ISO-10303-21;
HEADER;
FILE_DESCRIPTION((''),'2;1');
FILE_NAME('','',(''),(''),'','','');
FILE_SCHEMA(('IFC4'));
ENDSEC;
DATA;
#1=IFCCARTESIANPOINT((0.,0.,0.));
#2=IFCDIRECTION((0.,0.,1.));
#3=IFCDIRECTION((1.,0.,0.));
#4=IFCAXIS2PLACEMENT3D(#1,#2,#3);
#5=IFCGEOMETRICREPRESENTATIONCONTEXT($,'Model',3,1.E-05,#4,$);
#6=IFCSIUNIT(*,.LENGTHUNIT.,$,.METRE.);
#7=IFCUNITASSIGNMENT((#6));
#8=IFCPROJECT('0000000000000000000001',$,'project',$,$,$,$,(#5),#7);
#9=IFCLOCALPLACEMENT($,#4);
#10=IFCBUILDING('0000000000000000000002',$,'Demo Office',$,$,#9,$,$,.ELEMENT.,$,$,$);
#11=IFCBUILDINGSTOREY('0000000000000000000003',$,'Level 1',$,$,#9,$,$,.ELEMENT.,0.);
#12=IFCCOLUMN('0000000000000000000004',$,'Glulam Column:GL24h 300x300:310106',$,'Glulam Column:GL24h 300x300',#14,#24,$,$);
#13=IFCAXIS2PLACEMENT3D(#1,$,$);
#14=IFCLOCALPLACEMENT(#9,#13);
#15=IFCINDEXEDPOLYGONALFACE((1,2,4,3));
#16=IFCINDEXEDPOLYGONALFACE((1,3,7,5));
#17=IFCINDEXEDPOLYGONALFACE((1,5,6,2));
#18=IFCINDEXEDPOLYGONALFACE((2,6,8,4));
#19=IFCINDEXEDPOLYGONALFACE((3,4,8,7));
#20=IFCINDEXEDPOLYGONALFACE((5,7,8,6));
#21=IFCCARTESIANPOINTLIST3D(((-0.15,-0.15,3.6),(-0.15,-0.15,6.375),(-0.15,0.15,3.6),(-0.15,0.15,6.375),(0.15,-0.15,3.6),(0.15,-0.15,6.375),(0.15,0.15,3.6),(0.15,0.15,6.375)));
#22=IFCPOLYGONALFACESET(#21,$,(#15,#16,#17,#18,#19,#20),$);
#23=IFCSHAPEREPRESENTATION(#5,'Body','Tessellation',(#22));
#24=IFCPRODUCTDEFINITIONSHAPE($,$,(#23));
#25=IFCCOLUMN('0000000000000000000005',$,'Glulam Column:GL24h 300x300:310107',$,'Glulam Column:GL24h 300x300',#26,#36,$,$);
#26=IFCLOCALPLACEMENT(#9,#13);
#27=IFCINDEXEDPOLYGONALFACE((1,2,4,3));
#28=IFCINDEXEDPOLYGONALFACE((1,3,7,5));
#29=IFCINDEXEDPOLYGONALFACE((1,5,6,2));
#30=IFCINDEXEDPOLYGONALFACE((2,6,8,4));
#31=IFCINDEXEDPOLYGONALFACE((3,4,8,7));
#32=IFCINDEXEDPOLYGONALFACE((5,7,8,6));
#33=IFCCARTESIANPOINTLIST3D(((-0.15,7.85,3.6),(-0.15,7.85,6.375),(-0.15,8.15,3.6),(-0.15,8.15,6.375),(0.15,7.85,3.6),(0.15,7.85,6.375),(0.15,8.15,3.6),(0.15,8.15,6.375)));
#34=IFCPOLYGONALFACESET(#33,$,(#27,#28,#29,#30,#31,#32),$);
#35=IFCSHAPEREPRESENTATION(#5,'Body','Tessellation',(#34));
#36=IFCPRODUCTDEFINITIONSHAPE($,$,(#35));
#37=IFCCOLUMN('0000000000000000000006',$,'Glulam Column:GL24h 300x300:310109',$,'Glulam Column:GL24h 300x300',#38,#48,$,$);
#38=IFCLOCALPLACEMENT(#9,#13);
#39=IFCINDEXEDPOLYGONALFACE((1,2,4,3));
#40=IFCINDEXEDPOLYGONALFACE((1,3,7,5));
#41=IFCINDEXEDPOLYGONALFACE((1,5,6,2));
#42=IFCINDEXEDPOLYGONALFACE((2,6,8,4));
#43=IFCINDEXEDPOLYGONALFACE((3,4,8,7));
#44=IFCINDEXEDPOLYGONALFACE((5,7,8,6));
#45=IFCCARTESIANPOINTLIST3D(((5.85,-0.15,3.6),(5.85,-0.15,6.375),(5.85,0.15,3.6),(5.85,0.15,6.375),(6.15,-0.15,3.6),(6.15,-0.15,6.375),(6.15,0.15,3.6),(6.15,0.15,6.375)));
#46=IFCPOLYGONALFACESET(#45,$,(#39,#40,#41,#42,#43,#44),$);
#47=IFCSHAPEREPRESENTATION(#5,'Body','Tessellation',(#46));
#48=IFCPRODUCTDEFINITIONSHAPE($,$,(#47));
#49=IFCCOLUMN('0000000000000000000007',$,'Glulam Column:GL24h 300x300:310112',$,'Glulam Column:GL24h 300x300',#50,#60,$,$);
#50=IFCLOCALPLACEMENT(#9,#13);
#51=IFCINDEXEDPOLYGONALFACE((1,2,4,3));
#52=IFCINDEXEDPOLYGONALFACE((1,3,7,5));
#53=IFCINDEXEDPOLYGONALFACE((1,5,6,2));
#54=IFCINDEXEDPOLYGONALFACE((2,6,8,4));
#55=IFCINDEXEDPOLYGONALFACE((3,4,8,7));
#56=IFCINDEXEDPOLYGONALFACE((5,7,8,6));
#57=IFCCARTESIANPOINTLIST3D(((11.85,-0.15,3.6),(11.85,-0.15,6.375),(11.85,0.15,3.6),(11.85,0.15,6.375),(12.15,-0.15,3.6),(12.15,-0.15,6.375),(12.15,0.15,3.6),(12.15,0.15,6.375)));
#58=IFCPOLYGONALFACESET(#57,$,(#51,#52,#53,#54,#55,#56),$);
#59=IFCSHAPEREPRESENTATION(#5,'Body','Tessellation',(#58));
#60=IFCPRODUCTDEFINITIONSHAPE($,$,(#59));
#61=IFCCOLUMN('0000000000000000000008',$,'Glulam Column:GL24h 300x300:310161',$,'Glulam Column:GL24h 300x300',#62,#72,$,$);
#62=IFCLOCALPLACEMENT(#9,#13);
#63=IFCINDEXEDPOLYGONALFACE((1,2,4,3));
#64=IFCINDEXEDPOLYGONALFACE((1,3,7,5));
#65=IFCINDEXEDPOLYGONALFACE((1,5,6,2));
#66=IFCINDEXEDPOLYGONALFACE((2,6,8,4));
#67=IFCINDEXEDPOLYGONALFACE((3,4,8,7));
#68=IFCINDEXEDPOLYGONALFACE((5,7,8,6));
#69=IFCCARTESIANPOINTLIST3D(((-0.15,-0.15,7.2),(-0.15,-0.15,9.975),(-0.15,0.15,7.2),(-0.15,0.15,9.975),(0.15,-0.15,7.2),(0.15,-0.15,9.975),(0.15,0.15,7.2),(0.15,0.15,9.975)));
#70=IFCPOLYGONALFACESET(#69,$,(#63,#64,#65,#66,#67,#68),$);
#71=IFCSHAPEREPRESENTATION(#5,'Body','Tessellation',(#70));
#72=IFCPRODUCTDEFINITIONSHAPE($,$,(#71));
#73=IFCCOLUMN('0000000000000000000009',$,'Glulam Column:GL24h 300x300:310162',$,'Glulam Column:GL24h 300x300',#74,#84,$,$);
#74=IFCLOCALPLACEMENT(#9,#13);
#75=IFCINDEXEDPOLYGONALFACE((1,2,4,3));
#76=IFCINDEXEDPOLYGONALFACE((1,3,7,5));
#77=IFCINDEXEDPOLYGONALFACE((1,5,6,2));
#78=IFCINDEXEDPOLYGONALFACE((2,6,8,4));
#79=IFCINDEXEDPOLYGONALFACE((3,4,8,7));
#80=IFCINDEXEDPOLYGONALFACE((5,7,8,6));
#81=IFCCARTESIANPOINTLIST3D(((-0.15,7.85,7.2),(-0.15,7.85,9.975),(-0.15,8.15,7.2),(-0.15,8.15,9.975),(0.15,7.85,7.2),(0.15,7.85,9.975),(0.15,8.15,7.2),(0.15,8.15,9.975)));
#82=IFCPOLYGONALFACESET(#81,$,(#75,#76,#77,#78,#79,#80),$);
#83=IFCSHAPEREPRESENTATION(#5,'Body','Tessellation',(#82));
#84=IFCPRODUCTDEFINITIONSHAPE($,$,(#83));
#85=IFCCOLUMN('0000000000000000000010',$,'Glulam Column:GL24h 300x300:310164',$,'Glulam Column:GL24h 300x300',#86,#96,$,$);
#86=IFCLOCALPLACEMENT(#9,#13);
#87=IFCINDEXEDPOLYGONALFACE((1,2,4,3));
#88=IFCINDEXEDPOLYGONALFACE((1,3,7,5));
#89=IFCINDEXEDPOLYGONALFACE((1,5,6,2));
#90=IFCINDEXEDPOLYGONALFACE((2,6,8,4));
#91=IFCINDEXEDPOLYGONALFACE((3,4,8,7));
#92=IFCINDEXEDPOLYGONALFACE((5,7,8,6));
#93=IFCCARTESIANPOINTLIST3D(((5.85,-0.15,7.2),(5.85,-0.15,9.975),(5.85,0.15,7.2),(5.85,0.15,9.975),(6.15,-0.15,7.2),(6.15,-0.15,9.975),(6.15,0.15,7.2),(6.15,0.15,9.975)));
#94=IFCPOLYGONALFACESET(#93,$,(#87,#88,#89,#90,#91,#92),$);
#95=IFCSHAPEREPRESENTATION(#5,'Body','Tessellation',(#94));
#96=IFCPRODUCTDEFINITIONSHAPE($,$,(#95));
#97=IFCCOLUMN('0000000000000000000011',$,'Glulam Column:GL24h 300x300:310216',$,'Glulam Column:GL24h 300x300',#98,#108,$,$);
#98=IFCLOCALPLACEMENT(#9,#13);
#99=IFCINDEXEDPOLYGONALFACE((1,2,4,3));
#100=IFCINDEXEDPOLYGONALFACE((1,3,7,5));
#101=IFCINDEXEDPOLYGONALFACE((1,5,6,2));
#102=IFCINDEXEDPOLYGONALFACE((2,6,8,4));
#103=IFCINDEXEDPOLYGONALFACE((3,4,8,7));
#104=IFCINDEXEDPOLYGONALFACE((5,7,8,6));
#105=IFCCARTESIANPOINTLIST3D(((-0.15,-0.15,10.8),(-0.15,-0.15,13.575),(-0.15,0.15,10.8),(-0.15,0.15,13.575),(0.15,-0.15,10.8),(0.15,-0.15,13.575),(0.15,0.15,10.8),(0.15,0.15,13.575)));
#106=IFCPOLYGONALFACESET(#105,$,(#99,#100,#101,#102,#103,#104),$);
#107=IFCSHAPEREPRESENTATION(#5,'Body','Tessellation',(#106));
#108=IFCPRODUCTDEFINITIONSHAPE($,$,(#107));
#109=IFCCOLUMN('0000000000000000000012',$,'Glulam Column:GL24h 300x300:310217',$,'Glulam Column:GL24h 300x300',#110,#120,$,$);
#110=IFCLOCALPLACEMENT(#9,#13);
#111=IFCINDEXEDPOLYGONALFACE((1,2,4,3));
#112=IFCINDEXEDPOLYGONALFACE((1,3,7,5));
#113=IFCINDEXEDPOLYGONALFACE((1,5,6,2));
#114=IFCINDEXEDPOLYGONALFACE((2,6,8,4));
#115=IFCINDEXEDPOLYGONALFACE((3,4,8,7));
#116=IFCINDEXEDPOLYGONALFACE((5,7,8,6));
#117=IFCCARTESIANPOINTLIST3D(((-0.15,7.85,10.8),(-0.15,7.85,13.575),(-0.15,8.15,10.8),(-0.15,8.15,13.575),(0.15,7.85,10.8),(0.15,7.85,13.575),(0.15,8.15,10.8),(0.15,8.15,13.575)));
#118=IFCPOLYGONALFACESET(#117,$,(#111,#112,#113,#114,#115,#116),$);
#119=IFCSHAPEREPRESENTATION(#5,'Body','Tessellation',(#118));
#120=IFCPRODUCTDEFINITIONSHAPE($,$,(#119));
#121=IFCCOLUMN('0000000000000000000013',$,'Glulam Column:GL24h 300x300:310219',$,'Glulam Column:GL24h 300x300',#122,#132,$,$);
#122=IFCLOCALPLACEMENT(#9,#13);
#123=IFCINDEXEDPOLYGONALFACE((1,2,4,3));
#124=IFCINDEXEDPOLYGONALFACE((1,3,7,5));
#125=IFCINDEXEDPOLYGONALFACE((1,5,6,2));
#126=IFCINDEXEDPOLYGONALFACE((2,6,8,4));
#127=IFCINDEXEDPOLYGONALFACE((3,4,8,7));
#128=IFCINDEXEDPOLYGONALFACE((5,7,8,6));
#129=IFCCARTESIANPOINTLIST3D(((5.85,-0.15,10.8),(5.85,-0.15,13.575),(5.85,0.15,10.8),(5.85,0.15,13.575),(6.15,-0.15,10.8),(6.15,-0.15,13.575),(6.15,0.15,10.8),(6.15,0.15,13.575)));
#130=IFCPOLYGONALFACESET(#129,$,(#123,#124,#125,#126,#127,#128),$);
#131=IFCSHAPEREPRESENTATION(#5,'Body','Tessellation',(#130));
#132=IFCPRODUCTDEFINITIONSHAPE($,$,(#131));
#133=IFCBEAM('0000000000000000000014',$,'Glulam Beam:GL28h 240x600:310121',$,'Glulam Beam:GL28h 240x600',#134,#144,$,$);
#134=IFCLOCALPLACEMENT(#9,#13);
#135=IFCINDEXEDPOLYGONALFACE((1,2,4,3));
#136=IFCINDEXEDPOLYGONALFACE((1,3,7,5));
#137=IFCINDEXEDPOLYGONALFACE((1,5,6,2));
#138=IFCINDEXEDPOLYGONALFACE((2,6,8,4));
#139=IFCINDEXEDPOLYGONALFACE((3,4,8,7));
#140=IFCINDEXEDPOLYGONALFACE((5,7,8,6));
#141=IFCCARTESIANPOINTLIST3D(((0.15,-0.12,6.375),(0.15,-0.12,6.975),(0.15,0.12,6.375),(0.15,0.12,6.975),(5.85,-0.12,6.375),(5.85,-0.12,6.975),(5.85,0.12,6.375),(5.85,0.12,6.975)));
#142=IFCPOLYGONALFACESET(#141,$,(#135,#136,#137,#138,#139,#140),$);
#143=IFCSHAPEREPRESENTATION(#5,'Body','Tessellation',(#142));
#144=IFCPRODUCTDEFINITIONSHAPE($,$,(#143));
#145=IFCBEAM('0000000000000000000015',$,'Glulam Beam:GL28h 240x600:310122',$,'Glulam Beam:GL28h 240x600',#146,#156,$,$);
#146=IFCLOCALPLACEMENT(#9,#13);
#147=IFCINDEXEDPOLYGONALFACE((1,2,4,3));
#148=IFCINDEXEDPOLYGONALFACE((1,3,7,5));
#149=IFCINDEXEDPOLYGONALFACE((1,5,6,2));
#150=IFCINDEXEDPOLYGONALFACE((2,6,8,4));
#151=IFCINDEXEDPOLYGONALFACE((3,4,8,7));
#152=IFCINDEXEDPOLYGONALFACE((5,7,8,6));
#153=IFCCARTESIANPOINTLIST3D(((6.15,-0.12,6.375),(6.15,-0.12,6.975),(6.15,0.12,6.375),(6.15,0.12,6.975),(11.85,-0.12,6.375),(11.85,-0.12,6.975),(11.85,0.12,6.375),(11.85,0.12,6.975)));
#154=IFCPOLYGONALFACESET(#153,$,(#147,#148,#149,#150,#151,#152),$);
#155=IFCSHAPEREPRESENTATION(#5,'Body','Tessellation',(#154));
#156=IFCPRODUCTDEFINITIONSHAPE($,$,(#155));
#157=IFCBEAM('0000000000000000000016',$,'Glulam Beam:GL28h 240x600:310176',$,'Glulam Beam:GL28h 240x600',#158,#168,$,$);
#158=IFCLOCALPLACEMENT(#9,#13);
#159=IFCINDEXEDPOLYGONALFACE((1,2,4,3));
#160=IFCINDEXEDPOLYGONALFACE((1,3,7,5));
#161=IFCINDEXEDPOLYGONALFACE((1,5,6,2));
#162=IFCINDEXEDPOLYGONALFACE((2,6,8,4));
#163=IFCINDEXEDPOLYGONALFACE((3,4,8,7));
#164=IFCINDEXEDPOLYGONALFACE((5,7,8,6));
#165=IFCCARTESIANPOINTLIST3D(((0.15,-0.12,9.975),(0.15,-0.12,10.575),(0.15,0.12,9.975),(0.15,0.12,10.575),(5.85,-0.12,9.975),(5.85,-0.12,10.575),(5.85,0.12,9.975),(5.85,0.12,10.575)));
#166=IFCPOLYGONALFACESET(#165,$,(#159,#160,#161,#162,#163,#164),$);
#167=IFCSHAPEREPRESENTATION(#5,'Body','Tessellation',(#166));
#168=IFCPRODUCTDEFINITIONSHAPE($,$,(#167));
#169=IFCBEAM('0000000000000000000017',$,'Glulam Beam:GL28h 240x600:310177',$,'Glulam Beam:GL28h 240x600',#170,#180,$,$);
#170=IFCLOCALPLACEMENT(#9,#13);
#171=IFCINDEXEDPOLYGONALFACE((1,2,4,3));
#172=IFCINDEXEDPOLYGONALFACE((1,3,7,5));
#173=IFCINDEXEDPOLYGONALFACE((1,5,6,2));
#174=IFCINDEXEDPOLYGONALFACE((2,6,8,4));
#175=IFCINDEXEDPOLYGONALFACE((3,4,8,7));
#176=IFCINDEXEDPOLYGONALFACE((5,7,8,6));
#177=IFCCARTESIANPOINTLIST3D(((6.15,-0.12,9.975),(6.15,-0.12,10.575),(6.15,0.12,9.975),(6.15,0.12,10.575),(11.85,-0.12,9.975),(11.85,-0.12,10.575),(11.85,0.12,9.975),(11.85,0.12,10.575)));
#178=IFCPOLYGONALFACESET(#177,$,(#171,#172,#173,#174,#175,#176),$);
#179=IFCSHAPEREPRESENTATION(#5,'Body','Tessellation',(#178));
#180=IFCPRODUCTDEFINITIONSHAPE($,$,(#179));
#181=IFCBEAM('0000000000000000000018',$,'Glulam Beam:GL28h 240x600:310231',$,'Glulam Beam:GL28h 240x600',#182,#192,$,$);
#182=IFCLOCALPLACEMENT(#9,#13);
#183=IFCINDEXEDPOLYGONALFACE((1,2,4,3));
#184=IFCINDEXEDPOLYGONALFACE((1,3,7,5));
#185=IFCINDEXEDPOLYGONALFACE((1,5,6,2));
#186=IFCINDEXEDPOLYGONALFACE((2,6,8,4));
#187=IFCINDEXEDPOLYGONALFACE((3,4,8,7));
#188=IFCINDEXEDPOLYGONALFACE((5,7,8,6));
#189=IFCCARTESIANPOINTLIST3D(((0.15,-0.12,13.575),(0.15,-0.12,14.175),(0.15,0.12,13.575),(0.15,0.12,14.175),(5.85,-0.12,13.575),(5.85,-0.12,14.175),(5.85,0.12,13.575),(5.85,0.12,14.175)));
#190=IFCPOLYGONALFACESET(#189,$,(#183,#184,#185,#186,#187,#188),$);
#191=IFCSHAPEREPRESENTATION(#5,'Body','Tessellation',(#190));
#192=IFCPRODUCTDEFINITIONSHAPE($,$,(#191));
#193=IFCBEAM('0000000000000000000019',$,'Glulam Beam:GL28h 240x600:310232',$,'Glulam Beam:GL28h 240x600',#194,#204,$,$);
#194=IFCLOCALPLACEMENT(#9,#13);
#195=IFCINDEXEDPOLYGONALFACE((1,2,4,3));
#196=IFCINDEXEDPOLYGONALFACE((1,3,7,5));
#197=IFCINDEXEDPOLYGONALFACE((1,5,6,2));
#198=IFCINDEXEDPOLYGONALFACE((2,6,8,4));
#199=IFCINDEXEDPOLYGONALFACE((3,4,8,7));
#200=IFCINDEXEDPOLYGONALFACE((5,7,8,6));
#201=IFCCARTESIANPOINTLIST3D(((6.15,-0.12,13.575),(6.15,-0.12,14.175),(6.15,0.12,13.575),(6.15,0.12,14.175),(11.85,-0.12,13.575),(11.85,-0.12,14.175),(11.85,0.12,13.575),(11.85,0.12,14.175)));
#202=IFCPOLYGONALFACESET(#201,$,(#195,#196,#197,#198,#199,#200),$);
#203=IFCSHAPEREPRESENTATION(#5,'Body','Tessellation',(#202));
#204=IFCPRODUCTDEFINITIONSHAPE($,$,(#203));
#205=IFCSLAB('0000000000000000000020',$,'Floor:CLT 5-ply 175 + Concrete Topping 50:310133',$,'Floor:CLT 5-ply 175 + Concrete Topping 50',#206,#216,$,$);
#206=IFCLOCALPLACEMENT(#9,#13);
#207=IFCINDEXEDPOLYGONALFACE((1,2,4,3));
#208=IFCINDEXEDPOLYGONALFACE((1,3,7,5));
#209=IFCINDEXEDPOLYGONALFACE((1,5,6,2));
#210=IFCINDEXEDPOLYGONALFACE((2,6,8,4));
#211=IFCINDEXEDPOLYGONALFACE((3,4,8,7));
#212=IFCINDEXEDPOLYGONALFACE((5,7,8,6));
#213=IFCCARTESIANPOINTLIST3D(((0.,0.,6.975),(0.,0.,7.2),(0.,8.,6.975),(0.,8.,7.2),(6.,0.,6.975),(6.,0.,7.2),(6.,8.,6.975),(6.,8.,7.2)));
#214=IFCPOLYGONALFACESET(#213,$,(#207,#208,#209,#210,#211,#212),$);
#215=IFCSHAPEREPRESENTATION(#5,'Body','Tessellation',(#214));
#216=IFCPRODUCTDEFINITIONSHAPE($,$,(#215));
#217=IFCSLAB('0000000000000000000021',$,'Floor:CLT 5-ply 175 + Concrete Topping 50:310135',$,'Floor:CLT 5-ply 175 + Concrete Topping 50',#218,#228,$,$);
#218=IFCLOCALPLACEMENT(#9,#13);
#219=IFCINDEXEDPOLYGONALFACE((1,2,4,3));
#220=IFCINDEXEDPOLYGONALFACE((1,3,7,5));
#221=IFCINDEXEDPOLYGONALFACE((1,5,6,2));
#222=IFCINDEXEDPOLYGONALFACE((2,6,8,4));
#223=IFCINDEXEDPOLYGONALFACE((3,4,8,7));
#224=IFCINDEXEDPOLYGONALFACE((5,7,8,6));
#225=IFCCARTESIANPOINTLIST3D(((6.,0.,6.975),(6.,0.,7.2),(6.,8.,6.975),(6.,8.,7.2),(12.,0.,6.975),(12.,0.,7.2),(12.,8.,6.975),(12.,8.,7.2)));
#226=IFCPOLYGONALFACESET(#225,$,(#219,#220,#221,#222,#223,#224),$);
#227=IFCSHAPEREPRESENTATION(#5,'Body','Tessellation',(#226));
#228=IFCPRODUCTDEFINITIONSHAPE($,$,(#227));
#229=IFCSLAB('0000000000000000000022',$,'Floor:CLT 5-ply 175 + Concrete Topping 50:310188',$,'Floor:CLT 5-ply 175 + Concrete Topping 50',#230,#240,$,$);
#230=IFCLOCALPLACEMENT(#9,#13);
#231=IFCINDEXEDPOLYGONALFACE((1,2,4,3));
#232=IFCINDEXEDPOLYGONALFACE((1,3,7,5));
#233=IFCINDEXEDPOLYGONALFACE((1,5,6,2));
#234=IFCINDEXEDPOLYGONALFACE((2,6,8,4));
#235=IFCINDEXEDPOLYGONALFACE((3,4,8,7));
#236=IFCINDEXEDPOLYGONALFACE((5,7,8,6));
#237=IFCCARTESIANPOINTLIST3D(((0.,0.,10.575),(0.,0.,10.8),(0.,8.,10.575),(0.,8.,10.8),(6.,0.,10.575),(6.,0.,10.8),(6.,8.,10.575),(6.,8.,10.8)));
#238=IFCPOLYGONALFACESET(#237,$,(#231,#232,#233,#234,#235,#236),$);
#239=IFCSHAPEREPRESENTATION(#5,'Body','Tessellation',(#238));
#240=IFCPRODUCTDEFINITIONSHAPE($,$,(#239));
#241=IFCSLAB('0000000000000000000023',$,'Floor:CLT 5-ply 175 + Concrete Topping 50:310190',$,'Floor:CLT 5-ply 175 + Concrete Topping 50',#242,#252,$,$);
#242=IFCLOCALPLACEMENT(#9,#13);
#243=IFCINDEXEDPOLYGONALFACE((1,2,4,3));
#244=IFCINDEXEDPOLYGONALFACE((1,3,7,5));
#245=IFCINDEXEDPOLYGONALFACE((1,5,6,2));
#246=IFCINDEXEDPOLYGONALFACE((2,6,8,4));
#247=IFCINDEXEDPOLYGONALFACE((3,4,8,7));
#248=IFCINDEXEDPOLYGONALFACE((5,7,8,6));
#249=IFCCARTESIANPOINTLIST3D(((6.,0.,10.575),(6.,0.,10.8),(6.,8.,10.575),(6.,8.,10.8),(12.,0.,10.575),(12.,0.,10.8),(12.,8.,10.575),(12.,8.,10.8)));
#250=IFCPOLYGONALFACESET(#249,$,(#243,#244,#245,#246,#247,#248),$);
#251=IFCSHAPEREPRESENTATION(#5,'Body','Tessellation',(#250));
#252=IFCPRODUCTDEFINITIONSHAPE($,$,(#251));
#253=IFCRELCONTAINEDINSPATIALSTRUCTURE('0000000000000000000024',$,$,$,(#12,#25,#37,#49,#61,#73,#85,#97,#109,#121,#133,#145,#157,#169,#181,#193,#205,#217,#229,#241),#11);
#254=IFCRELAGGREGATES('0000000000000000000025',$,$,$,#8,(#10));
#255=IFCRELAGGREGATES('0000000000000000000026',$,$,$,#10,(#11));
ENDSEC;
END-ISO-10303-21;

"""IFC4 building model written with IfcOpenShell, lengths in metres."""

from ifc_helpers import new_model, si_unit, frame, origin_with_axes, origin_2d, place, context, project, spatial, rectangle, extrude, element, save


model = new_model("IFC4")

# Units and contexts
model_context = context("Model", 3, precision=1e-05, world=origin_with_axes())
ifc_project = project(units=[si_unit("LENGTHUNIT", "METRE")], contexts=[model_context])

# Building, storey
placement = place(None, origin_with_axes())
building = spatial("IfcBuilding", under=ifc_project, at=placement, Name="Demo Office", CompositionType="ELEMENT")
storey = spatial("IfcBuildingStorey", under=building, at=placement, Name="Level 1", CompositionType="ELEMENT", Elevation=0.0)

# Columns
for number, where, name in (
    (1, (0.0, 0.0, 3.6), "Glulam Column:GL24h 300x300:310106"),
    (2, (0.0, 8.0, 3.6), "Glulam Column:GL24h 300x300:310107"),
    (3, (6.0, 0.0, 3.6), "Glulam Column:GL24h 300x300:310109"),
    (4, (12.0, 0.0, 3.6), "Glulam Column:GL24h 300x300:310112"),
    (5, (0.0, 0.0, 7.2), "Glulam Column:GL24h 300x300:310161"),
    (6, (0.0, 8.0, 7.2), "Glulam Column:GL24h 300x300:310162"),
    (7, (6.0, 0.0, 7.2), "Glulam Column:GL24h 300x300:310164"),
    (8, (0.0, 0.0, 10.8), "Glulam Column:GL24h 300x300:310216"),
    (9, (0.0, 8.0, 10.8), "Glulam Column:GL24h 300x300:310217"),
    (10, (6.0, 0.0, 10.8), "Glulam Column:GL24h 300x300:310219"),
):
    element("IfcColumn", number, at=place(placement, frame(where)), inside=storey, Name=name, ObjectType="Glulam Column:GL24h 300x300", context=model_context, shape_type="SweptSolid", body=[
        extrude(rectangle(XDim=0.3, YDim=0.3, at=origin_2d()), origin_with_axes(), (0.0, 0.0, 1.0), 2.775),
    ])

# Beams
for number, where, name in (
    (11, (3.0, 0.0, 6.375), "Glulam Beam:GL28h 240x600:310121"),
    (12, (9.0, 0.0, 6.375), "Glulam Beam:GL28h 240x600:310122"),
    (13, (3.0, 0.0, 9.975), "Glulam Beam:GL28h 240x600:310176"),
    (14, (9.0, 0.0, 9.975), "Glulam Beam:GL28h 240x600:310177"),
    (15, (3.0, 0.0, 13.575), "Glulam Beam:GL28h 240x600:310231"),
    (16, (9.0, 0.0, 13.575), "Glulam Beam:GL28h 240x600:310232"),
):
    element("IfcBeam", number, at=place(placement, frame(where)), inside=storey, Name=name, ObjectType="Glulam Beam:GL28h 240x600", context=model_context, shape_type="SweptSolid", body=[
        extrude(rectangle(XDim=5.7, YDim=0.24, at=origin_2d()), origin_with_axes(), (0.0, 0.0, 1.0), 0.6),
    ])

# Slabs
for number, where, name in (
    (17, (3.0, 4.0, 6.975), "Floor:CLT 5-ply 175 + Concrete Topping 50:310133"),
    (18, (9.0, 4.0, 6.975), "Floor:CLT 5-ply 175 + Concrete Topping 50:310135"),
    (19, (3.0, 4.0, 10.575), "Floor:CLT 5-ply 175 + Concrete Topping 50:310188"),
    (20, (9.0, 4.0, 10.575), "Floor:CLT 5-ply 175 + Concrete Topping 50:310190"),
):
    element("IfcSlab", number, at=place(placement, frame(where)), inside=storey, Name=name, ObjectType="Floor:CLT 5-ply 175 + Concrete Topping 50", context=model_context, shape_type="SweptSolid", body=[
        extrude(rectangle(XDim=6.0, YDim=8.0, at=origin_2d()), origin_with_axes(), (0.0, 0.0, 1.0), 0.225),
    ])

save(model, "model.ifc")
